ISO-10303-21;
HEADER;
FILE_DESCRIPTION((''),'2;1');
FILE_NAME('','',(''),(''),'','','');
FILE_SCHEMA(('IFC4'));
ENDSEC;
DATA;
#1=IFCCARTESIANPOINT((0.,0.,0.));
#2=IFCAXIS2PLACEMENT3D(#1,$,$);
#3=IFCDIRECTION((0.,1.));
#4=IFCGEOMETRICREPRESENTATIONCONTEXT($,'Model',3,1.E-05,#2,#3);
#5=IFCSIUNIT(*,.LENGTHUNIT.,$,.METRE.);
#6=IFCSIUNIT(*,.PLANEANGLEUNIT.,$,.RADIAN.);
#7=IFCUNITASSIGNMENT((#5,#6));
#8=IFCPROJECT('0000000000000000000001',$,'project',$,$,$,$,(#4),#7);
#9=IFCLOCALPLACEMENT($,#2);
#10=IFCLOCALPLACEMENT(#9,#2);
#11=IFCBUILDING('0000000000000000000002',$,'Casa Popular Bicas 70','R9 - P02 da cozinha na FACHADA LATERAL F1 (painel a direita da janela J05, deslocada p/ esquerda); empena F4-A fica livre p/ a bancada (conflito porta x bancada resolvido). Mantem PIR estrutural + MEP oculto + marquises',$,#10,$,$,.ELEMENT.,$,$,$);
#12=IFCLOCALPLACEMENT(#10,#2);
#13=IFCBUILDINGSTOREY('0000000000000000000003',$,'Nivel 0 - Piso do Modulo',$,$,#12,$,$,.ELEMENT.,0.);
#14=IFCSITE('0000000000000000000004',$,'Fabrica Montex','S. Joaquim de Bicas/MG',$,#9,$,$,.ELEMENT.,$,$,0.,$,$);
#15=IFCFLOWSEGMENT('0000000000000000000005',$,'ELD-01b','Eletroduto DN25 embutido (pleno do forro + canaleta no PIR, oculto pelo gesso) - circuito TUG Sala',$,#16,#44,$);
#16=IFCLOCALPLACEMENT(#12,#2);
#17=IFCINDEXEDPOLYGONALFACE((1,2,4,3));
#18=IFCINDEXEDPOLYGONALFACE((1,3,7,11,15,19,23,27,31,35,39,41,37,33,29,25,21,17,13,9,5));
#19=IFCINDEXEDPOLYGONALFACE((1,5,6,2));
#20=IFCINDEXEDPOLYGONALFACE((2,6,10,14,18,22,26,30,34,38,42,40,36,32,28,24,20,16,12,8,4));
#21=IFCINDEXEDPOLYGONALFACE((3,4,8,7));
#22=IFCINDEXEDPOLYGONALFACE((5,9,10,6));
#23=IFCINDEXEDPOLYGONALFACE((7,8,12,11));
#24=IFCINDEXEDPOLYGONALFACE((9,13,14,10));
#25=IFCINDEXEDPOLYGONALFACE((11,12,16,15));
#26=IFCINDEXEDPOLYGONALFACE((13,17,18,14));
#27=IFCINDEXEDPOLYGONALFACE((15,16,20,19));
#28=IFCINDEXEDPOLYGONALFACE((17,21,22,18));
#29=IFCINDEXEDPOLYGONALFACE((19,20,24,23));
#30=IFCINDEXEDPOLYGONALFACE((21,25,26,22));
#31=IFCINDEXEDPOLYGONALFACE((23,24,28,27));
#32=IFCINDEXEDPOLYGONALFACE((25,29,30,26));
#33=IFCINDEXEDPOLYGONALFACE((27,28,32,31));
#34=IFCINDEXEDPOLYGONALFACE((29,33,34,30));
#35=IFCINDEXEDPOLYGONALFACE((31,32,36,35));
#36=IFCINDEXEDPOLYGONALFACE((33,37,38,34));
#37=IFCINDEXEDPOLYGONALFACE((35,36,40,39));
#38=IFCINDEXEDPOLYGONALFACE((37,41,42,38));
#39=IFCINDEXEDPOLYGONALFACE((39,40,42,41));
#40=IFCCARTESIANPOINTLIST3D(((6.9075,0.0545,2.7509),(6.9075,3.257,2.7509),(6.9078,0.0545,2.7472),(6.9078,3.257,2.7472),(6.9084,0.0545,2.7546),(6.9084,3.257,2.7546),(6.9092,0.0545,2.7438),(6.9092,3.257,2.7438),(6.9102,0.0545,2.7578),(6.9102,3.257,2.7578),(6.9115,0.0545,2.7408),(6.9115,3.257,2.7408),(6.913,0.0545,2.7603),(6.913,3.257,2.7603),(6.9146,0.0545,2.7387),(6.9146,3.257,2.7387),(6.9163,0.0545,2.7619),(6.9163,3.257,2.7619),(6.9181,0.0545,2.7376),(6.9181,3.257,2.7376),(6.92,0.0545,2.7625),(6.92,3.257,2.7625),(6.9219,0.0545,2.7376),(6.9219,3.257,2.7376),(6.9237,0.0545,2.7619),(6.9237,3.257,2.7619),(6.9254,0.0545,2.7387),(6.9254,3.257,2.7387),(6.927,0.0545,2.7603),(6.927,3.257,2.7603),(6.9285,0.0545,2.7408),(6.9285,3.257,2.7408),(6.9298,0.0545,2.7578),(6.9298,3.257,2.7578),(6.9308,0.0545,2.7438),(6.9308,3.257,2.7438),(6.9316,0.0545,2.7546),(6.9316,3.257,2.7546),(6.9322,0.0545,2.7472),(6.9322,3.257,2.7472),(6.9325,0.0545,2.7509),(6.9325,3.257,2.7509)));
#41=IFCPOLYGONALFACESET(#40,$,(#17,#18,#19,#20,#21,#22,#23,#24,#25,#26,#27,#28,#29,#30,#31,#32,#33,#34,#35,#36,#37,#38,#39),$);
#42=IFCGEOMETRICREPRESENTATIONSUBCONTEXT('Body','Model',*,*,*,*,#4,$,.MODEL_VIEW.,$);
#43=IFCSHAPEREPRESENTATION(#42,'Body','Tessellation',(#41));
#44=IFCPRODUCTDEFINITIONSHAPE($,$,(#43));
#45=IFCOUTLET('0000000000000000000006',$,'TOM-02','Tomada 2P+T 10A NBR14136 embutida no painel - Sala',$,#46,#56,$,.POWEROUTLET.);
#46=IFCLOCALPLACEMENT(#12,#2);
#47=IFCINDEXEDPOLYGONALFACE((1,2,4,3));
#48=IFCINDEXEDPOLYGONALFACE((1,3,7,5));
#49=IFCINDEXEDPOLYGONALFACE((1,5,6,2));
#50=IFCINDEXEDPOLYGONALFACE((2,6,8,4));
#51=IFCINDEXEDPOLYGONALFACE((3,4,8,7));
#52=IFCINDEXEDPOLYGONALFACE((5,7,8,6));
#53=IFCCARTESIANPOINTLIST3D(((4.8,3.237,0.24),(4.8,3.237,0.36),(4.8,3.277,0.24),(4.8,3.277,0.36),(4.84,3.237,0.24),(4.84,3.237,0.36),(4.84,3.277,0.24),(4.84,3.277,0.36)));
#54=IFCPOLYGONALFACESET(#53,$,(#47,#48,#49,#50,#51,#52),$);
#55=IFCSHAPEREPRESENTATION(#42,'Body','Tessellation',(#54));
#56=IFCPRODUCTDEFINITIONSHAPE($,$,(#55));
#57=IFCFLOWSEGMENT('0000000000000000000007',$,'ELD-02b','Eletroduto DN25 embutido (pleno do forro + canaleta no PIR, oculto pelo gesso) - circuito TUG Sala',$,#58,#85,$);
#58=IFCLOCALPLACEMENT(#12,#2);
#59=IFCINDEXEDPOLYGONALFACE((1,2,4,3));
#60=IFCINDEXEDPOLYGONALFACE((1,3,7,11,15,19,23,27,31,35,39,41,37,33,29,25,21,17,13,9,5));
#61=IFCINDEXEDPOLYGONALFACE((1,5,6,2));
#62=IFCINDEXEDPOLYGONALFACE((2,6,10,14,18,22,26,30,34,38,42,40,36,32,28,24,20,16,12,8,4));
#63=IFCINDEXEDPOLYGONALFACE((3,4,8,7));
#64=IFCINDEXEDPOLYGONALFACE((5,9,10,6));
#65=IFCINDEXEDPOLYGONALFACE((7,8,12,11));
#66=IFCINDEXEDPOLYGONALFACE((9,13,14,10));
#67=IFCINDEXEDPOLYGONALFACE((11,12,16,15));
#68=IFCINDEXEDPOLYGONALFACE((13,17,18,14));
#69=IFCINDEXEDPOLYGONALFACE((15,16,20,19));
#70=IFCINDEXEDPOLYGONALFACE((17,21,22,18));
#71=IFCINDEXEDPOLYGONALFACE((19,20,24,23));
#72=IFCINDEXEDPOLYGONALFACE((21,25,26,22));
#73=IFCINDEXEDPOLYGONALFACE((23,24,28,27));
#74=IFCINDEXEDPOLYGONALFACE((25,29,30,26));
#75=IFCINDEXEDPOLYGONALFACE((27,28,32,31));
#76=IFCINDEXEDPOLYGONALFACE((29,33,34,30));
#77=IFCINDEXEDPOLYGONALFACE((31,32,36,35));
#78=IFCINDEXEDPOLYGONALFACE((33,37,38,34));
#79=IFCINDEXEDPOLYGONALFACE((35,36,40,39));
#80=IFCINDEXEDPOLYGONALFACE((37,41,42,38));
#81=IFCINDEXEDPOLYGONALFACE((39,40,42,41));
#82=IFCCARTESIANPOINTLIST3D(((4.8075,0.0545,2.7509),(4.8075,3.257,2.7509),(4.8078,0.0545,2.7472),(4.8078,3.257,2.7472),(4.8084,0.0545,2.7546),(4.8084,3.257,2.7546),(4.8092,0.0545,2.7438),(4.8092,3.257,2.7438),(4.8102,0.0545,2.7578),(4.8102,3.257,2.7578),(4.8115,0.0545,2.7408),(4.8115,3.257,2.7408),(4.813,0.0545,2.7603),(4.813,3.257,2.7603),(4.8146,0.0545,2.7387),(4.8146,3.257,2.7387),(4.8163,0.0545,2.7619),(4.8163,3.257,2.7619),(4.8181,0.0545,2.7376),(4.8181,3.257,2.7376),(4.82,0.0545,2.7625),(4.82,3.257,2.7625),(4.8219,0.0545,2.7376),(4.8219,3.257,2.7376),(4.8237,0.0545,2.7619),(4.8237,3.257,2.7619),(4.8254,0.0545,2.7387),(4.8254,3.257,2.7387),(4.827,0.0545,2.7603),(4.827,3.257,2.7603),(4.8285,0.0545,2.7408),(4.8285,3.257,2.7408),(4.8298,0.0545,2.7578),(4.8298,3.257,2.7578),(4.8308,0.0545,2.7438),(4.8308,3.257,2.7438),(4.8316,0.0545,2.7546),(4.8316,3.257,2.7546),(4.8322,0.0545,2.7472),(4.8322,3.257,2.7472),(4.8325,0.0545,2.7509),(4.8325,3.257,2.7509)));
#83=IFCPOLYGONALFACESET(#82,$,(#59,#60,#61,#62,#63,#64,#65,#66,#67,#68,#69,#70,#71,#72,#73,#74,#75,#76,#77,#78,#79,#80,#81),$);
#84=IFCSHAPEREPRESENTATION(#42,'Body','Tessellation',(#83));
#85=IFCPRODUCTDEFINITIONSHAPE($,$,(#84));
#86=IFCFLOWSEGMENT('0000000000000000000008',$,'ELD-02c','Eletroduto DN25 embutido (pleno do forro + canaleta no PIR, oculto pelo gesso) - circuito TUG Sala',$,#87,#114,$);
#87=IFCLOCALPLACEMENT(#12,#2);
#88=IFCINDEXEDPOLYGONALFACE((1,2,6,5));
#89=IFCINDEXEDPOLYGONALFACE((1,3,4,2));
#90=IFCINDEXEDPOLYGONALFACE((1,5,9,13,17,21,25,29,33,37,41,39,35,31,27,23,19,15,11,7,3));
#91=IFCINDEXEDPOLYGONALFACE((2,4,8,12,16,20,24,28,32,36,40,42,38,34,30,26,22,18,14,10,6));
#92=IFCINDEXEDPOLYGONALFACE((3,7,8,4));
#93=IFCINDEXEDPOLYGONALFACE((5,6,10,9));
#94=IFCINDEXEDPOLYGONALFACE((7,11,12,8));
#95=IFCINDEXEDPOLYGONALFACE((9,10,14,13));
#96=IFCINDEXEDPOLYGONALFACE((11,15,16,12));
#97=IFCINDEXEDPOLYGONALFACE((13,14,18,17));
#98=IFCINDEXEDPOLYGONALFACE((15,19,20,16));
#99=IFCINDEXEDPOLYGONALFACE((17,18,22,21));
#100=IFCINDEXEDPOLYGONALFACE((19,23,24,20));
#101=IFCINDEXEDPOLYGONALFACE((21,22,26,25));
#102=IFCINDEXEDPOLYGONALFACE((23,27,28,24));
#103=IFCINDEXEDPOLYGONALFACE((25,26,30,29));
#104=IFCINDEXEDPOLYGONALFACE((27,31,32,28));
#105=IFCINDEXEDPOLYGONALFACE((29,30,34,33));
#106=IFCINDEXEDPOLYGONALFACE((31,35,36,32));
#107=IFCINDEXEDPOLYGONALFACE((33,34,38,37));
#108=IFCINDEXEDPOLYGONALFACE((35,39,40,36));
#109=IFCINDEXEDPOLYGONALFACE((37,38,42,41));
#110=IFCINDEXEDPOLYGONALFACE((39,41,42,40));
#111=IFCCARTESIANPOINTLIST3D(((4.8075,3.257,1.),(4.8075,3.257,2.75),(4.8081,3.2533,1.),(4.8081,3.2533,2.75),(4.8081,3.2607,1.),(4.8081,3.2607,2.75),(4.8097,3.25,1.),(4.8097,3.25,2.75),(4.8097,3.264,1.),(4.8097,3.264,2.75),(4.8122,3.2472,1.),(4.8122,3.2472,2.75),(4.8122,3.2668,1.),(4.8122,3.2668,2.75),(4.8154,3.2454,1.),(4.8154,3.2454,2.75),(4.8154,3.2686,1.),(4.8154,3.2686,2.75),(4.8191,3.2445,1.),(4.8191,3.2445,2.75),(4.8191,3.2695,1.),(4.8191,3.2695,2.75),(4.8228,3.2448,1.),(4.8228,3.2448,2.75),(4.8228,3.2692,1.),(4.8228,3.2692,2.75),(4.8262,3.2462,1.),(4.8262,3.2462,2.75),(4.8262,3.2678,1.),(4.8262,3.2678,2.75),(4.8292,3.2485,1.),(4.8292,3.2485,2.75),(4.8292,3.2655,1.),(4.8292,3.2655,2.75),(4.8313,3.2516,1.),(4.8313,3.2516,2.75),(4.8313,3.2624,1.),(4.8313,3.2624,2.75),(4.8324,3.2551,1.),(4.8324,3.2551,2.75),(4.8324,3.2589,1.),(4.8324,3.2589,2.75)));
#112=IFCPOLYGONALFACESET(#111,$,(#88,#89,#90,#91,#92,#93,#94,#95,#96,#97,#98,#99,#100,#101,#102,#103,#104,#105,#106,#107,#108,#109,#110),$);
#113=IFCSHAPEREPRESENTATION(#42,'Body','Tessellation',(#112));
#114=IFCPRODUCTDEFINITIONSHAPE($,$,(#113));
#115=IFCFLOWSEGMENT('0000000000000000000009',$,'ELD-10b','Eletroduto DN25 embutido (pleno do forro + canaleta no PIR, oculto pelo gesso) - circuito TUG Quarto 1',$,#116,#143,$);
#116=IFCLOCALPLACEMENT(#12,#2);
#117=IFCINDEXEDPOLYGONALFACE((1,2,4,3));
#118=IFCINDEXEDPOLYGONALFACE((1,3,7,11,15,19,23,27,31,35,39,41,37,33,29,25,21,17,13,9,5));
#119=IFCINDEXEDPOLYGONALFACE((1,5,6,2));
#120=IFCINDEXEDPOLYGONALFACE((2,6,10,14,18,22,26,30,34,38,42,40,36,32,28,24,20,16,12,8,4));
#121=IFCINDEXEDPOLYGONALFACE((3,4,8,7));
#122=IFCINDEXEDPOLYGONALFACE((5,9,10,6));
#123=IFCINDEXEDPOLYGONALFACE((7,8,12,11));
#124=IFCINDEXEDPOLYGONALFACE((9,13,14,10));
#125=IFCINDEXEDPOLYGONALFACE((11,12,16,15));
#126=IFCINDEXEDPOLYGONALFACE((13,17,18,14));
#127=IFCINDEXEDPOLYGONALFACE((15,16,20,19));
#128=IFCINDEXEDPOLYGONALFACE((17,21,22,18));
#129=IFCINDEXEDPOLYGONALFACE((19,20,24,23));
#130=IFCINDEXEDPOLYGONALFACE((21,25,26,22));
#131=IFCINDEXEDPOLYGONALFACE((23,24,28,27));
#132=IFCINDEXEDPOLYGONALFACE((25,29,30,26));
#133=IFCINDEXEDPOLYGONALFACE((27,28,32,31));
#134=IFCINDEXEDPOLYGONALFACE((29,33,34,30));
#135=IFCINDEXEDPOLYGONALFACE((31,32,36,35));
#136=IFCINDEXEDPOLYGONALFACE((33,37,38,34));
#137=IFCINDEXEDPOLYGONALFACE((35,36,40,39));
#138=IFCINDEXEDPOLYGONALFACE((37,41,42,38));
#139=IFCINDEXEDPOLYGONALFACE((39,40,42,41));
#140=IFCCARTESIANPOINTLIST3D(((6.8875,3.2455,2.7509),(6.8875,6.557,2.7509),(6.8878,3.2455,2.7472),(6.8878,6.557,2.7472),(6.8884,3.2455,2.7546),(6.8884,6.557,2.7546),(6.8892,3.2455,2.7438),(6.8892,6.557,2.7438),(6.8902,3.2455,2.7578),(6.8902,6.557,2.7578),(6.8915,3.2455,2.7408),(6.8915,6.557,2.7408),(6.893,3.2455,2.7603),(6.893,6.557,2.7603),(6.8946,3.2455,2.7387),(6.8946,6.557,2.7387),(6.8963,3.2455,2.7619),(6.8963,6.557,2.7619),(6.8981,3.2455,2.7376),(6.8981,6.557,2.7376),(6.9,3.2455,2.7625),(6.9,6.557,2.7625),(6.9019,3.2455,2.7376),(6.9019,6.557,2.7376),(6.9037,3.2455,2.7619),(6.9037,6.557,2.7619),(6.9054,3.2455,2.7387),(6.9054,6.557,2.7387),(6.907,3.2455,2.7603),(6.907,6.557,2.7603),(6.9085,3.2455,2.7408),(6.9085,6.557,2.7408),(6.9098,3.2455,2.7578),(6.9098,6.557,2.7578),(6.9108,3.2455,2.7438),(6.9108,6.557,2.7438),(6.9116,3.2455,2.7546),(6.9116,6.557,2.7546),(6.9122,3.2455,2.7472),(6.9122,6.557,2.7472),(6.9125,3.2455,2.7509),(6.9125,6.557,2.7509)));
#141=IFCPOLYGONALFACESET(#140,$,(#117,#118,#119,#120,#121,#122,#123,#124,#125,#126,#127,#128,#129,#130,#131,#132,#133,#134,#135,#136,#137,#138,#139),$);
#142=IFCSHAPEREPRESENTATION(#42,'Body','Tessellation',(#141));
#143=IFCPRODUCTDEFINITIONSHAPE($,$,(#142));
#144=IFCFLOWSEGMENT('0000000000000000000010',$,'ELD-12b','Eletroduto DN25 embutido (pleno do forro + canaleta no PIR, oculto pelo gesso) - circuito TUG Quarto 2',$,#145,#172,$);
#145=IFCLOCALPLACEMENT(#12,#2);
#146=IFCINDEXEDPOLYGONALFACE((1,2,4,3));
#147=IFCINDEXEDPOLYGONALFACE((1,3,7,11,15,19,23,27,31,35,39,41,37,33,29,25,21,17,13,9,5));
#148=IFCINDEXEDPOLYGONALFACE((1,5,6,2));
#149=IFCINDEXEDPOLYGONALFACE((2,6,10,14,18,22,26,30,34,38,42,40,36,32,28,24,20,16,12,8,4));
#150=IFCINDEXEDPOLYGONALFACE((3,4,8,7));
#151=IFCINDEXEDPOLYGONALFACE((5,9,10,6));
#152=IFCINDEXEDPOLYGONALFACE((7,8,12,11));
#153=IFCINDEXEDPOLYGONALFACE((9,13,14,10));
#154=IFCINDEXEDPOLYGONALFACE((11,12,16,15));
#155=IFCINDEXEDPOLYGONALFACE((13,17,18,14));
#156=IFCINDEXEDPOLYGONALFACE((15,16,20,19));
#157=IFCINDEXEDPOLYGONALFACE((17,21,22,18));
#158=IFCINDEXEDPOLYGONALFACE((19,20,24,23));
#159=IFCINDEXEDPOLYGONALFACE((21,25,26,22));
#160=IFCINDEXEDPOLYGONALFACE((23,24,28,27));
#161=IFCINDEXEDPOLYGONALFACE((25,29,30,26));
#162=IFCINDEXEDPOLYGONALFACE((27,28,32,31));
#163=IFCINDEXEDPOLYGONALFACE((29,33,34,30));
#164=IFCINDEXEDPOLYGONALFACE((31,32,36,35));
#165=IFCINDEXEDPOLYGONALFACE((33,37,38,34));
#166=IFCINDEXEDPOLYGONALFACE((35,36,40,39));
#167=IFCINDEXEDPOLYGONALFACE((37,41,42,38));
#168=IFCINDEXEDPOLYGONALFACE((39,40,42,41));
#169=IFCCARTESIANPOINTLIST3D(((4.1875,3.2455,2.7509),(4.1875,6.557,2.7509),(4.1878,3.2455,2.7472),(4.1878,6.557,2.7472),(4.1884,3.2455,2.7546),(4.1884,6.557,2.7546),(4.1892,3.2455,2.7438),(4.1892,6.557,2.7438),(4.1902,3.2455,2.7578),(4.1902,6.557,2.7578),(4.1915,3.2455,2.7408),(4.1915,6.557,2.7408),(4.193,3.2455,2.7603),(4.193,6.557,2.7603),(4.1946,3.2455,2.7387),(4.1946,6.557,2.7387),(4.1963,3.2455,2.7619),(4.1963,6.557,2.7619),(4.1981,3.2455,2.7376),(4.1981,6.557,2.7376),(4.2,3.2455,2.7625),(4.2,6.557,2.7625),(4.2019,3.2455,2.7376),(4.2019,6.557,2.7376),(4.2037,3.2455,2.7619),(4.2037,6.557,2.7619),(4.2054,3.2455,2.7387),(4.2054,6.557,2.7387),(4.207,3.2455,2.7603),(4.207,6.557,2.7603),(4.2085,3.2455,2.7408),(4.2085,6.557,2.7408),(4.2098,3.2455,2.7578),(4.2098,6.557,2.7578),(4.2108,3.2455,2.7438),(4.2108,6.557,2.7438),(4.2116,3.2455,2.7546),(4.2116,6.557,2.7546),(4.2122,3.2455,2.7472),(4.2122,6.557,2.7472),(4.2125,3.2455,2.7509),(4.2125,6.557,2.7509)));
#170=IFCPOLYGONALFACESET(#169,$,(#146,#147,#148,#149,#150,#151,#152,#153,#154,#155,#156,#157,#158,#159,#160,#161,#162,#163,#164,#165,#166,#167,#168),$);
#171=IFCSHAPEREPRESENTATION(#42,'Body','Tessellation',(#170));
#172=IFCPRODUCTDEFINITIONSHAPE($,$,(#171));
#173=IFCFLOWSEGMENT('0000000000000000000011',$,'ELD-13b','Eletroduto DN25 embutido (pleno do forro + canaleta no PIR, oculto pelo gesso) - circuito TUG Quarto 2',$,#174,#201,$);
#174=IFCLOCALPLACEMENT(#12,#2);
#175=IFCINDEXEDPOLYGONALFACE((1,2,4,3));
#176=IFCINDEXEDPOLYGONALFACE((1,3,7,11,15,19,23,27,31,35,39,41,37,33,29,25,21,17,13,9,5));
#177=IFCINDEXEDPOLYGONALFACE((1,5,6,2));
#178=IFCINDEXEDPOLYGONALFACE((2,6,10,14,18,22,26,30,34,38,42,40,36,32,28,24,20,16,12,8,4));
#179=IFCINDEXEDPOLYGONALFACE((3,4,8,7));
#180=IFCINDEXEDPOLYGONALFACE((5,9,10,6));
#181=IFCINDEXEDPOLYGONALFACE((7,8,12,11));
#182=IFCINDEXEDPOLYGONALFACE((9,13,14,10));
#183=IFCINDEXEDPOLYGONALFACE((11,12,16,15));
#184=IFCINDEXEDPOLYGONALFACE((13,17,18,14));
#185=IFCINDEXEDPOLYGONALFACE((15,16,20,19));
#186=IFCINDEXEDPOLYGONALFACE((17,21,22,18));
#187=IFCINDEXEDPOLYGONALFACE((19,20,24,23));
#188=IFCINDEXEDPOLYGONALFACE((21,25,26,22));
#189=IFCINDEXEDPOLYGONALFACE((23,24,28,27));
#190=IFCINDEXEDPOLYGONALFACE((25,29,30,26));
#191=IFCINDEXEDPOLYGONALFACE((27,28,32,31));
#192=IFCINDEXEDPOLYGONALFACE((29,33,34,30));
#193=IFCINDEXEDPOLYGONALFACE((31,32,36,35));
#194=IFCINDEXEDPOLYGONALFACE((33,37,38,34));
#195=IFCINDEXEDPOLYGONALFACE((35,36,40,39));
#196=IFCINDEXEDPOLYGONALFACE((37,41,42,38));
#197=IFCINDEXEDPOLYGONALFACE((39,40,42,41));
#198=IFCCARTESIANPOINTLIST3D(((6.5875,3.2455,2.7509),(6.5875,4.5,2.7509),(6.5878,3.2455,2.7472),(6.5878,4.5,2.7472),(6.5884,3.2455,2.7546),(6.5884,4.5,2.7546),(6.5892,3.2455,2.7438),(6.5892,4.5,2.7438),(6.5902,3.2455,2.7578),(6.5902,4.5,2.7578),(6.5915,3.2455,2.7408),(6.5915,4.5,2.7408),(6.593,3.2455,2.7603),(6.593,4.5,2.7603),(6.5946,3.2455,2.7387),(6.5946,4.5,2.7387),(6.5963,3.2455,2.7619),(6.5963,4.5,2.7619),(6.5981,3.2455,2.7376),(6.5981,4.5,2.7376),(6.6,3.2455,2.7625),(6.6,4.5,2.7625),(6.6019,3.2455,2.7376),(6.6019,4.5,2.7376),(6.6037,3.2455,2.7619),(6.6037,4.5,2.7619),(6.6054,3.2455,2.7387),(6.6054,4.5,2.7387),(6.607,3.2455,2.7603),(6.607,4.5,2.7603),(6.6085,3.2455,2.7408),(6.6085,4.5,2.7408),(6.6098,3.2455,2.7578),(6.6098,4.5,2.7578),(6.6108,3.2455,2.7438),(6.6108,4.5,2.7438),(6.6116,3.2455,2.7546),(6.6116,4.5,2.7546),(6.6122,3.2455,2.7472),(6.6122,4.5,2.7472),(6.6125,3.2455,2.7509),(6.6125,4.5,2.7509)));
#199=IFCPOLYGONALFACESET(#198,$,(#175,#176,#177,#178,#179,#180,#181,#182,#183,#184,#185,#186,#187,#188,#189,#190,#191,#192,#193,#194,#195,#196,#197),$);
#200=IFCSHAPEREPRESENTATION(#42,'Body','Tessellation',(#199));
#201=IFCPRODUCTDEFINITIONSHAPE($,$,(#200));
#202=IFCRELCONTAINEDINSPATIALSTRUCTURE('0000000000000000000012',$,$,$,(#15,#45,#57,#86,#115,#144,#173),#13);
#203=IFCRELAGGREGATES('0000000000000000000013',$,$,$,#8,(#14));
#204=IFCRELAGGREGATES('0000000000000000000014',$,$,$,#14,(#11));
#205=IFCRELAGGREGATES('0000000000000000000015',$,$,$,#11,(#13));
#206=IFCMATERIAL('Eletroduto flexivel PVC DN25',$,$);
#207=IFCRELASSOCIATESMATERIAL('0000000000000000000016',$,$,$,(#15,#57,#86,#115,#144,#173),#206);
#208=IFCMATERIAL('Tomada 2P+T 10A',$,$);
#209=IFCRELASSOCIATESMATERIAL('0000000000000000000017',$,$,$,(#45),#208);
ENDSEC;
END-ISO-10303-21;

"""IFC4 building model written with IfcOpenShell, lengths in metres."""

from ifc_helpers import new_model, si_unit, direction, frame, frame_2d, origin, origin_2d, place, context, subcontext, project, spatial, rectangle, circle, extrude, material, element, save


model = new_model("IFC4")

# Units and contexts
model_context = context("Model", 3, precision=1e-05, world=origin(), true_north=direction((0.0, 1.0)))
body_context = subcontext(model_context, "Body", "Model", "MODEL_VIEW")
ifc_project = project(units=[si_unit("LENGTHUNIT", "METRE"), si_unit("PLANEANGLEUNIT", "RADIAN")], contexts=[model_context])

# Site, building, storey
site_placement = place(None, origin())
site = spatial("IfcSite", under=ifc_project, at=site_placement, Name="Fabrica Montex", Description="S. Joaquim de Bicas/MG", CompositionType="ELEMENT", RefElevation=0.0)
building_placement = place(site_placement, origin())
building = spatial("IfcBuilding", under=site, at=building_placement, Name="Casa Popular Bicas 70", Description="R9 - P02 da cozinha na FACHADA LATERAL F1 (painel a direita da janela J05, deslocada p/ esquerda); empena F4-A fica livre p/ a bancada (conflito porta x bancada resolvido). Mantem PIR estrutural + MEP oculto + marquises", CompositionType="ELEMENT")
storey_placement = place(building_placement, origin())
storey = spatial("IfcBuildingStorey", under=building, at=storey_placement, Name="Nivel 0 - Piso do Modulo", CompositionType="ELEMENT", Elevation=0.0)

# Flow segment
ifc_material_1 = material(Name="Eletroduto flexivel PVC DN25")
flow_segment_1_placement = place(None, frame((6.92, 0.0545, 2.75), z_axis=(0.0, 1.0, 0.0), x_axis=(0.0, 0.0, 1.0)))
element("IfcFlowSegment", 1, at=flow_segment_1_placement, inside=storey, material=ifc_material_1, Name="ELD-01b", Description="Eletroduto DN25 embutido (pleno do forro + canaleta no PIR, oculto pelo gesso) - circuito TUG Sala", context=body_context, shape_type="SweptSolid", body=[
    extrude(circle(Radius=0.0125, at=origin_2d()), origin(), (0.0, 0.0, 1.0), 3.2025),
])

# Outlet
ifc_material_2 = material(Name="Tomada 2P+T 10A")
outlet_placement = place(None, frame((4.84, 3.277, 0.24), z_axis=(0.0, 0.0, 1.0), x_axis=(-1.0, 0.0, 0.0)))
element("IfcOutlet", 2, at=outlet_placement, inside=storey, material=ifc_material_2, Name="TOM-02", Description="Tomada 2P+T 10A NBR14136 embutida no painel - Sala", PredefinedType="POWEROUTLET", context=body_context, shape_type="SweptSolid", body=[
    extrude(rectangle(XDim=0.04, YDim=0.04, at=frame_2d((0.02, 0.02))), origin(), (0.0, 0.0, 1.0), 0.12),
])

# Flow segments
flow_segment_2_placement = place(None, frame((4.82, 0.0545, 2.75), z_axis=(0.0, 1.0, 0.0), x_axis=(0.0, 0.0, 1.0)))
element("IfcFlowSegment", 3, at=flow_segment_2_placement, inside=storey, material=ifc_material_1, Name="ELD-02b", Description="Eletroduto DN25 embutido (pleno do forro + canaleta no PIR, oculto pelo gesso) - circuito TUG Sala", context=body_context, shape_type="SweptSolid", body=[
    extrude(circle(Radius=0.0125, at=origin_2d()), origin(), (0.0, 0.0, 1.0), 3.2025),
])
flow_segment_3_placement = place(None, frame((4.82, 3.257, 2.75), z_axis=(0.0, 0.0, -1.0), x_axis=(-1.0, 0.0, 0.0)))
element("IfcFlowSegment", 4, at=flow_segment_3_placement, inside=storey, material=ifc_material_1, Name="ELD-02c", Description="Eletroduto DN25 embutido (pleno do forro + canaleta no PIR, oculto pelo gesso) - circuito TUG Sala", context=body_context, shape_type="SweptSolid", body=[
    extrude(circle(Radius=0.0125, at=origin_2d()), origin(), (0.0, 0.0, 1.0), 1.75),
])
for number, where, z_axis, x_axis, name, description in (
    (5, (6.9, 3.2455, 2.75), (0.0, 1.0, 0.0), (0.0, 0.0, 1.0), "ELD-10b", "Eletroduto DN25 embutido (pleno do forro + canaleta no PIR, oculto pelo gesso) - circuito TUG Quarto 1"),
    (6, (4.2, 3.2455, 2.75), (0.0, 1.0, 0.0), (0.0, 0.0, 1.0), "ELD-12b", "Eletroduto DN25 embutido (pleno do forro + canaleta no PIR, oculto pelo gesso) - circuito TUG Quarto 2"),
):
    element("IfcFlowSegment", number, at=place(storey_placement, frame(where, z_axis=z_axis, x_axis=x_axis)), inside=storey, material=ifc_material_1, Name=name, Description=description, context=body_context, shape_type="SweptSolid", body=[
        extrude(circle(Radius=0.0125, at=origin_2d()), origin(), (0.0, 0.0, 1.0), 3.3115),
    ])
flow_segment_4_placement = place(storey_placement, frame((6.6, 3.2455, 2.75), z_axis=(0.0, 1.0, 0.0), x_axis=(0.0, 0.0, 1.0)))
element("IfcFlowSegment", 7, at=flow_segment_4_placement, inside=storey, material=ifc_material_1, Name="ELD-13b", Description="Eletroduto DN25 embutido (pleno do forro + canaleta no PIR, oculto pelo gesso) - circuito TUG Quarto 2", context=body_context, shape_type="SweptSolid", body=[
    extrude(circle(Radius=0.0125, at=origin_2d()), origin(), (0.0, 0.0, 1.0), 1.2545),
])

save(model, "model.ifc")
